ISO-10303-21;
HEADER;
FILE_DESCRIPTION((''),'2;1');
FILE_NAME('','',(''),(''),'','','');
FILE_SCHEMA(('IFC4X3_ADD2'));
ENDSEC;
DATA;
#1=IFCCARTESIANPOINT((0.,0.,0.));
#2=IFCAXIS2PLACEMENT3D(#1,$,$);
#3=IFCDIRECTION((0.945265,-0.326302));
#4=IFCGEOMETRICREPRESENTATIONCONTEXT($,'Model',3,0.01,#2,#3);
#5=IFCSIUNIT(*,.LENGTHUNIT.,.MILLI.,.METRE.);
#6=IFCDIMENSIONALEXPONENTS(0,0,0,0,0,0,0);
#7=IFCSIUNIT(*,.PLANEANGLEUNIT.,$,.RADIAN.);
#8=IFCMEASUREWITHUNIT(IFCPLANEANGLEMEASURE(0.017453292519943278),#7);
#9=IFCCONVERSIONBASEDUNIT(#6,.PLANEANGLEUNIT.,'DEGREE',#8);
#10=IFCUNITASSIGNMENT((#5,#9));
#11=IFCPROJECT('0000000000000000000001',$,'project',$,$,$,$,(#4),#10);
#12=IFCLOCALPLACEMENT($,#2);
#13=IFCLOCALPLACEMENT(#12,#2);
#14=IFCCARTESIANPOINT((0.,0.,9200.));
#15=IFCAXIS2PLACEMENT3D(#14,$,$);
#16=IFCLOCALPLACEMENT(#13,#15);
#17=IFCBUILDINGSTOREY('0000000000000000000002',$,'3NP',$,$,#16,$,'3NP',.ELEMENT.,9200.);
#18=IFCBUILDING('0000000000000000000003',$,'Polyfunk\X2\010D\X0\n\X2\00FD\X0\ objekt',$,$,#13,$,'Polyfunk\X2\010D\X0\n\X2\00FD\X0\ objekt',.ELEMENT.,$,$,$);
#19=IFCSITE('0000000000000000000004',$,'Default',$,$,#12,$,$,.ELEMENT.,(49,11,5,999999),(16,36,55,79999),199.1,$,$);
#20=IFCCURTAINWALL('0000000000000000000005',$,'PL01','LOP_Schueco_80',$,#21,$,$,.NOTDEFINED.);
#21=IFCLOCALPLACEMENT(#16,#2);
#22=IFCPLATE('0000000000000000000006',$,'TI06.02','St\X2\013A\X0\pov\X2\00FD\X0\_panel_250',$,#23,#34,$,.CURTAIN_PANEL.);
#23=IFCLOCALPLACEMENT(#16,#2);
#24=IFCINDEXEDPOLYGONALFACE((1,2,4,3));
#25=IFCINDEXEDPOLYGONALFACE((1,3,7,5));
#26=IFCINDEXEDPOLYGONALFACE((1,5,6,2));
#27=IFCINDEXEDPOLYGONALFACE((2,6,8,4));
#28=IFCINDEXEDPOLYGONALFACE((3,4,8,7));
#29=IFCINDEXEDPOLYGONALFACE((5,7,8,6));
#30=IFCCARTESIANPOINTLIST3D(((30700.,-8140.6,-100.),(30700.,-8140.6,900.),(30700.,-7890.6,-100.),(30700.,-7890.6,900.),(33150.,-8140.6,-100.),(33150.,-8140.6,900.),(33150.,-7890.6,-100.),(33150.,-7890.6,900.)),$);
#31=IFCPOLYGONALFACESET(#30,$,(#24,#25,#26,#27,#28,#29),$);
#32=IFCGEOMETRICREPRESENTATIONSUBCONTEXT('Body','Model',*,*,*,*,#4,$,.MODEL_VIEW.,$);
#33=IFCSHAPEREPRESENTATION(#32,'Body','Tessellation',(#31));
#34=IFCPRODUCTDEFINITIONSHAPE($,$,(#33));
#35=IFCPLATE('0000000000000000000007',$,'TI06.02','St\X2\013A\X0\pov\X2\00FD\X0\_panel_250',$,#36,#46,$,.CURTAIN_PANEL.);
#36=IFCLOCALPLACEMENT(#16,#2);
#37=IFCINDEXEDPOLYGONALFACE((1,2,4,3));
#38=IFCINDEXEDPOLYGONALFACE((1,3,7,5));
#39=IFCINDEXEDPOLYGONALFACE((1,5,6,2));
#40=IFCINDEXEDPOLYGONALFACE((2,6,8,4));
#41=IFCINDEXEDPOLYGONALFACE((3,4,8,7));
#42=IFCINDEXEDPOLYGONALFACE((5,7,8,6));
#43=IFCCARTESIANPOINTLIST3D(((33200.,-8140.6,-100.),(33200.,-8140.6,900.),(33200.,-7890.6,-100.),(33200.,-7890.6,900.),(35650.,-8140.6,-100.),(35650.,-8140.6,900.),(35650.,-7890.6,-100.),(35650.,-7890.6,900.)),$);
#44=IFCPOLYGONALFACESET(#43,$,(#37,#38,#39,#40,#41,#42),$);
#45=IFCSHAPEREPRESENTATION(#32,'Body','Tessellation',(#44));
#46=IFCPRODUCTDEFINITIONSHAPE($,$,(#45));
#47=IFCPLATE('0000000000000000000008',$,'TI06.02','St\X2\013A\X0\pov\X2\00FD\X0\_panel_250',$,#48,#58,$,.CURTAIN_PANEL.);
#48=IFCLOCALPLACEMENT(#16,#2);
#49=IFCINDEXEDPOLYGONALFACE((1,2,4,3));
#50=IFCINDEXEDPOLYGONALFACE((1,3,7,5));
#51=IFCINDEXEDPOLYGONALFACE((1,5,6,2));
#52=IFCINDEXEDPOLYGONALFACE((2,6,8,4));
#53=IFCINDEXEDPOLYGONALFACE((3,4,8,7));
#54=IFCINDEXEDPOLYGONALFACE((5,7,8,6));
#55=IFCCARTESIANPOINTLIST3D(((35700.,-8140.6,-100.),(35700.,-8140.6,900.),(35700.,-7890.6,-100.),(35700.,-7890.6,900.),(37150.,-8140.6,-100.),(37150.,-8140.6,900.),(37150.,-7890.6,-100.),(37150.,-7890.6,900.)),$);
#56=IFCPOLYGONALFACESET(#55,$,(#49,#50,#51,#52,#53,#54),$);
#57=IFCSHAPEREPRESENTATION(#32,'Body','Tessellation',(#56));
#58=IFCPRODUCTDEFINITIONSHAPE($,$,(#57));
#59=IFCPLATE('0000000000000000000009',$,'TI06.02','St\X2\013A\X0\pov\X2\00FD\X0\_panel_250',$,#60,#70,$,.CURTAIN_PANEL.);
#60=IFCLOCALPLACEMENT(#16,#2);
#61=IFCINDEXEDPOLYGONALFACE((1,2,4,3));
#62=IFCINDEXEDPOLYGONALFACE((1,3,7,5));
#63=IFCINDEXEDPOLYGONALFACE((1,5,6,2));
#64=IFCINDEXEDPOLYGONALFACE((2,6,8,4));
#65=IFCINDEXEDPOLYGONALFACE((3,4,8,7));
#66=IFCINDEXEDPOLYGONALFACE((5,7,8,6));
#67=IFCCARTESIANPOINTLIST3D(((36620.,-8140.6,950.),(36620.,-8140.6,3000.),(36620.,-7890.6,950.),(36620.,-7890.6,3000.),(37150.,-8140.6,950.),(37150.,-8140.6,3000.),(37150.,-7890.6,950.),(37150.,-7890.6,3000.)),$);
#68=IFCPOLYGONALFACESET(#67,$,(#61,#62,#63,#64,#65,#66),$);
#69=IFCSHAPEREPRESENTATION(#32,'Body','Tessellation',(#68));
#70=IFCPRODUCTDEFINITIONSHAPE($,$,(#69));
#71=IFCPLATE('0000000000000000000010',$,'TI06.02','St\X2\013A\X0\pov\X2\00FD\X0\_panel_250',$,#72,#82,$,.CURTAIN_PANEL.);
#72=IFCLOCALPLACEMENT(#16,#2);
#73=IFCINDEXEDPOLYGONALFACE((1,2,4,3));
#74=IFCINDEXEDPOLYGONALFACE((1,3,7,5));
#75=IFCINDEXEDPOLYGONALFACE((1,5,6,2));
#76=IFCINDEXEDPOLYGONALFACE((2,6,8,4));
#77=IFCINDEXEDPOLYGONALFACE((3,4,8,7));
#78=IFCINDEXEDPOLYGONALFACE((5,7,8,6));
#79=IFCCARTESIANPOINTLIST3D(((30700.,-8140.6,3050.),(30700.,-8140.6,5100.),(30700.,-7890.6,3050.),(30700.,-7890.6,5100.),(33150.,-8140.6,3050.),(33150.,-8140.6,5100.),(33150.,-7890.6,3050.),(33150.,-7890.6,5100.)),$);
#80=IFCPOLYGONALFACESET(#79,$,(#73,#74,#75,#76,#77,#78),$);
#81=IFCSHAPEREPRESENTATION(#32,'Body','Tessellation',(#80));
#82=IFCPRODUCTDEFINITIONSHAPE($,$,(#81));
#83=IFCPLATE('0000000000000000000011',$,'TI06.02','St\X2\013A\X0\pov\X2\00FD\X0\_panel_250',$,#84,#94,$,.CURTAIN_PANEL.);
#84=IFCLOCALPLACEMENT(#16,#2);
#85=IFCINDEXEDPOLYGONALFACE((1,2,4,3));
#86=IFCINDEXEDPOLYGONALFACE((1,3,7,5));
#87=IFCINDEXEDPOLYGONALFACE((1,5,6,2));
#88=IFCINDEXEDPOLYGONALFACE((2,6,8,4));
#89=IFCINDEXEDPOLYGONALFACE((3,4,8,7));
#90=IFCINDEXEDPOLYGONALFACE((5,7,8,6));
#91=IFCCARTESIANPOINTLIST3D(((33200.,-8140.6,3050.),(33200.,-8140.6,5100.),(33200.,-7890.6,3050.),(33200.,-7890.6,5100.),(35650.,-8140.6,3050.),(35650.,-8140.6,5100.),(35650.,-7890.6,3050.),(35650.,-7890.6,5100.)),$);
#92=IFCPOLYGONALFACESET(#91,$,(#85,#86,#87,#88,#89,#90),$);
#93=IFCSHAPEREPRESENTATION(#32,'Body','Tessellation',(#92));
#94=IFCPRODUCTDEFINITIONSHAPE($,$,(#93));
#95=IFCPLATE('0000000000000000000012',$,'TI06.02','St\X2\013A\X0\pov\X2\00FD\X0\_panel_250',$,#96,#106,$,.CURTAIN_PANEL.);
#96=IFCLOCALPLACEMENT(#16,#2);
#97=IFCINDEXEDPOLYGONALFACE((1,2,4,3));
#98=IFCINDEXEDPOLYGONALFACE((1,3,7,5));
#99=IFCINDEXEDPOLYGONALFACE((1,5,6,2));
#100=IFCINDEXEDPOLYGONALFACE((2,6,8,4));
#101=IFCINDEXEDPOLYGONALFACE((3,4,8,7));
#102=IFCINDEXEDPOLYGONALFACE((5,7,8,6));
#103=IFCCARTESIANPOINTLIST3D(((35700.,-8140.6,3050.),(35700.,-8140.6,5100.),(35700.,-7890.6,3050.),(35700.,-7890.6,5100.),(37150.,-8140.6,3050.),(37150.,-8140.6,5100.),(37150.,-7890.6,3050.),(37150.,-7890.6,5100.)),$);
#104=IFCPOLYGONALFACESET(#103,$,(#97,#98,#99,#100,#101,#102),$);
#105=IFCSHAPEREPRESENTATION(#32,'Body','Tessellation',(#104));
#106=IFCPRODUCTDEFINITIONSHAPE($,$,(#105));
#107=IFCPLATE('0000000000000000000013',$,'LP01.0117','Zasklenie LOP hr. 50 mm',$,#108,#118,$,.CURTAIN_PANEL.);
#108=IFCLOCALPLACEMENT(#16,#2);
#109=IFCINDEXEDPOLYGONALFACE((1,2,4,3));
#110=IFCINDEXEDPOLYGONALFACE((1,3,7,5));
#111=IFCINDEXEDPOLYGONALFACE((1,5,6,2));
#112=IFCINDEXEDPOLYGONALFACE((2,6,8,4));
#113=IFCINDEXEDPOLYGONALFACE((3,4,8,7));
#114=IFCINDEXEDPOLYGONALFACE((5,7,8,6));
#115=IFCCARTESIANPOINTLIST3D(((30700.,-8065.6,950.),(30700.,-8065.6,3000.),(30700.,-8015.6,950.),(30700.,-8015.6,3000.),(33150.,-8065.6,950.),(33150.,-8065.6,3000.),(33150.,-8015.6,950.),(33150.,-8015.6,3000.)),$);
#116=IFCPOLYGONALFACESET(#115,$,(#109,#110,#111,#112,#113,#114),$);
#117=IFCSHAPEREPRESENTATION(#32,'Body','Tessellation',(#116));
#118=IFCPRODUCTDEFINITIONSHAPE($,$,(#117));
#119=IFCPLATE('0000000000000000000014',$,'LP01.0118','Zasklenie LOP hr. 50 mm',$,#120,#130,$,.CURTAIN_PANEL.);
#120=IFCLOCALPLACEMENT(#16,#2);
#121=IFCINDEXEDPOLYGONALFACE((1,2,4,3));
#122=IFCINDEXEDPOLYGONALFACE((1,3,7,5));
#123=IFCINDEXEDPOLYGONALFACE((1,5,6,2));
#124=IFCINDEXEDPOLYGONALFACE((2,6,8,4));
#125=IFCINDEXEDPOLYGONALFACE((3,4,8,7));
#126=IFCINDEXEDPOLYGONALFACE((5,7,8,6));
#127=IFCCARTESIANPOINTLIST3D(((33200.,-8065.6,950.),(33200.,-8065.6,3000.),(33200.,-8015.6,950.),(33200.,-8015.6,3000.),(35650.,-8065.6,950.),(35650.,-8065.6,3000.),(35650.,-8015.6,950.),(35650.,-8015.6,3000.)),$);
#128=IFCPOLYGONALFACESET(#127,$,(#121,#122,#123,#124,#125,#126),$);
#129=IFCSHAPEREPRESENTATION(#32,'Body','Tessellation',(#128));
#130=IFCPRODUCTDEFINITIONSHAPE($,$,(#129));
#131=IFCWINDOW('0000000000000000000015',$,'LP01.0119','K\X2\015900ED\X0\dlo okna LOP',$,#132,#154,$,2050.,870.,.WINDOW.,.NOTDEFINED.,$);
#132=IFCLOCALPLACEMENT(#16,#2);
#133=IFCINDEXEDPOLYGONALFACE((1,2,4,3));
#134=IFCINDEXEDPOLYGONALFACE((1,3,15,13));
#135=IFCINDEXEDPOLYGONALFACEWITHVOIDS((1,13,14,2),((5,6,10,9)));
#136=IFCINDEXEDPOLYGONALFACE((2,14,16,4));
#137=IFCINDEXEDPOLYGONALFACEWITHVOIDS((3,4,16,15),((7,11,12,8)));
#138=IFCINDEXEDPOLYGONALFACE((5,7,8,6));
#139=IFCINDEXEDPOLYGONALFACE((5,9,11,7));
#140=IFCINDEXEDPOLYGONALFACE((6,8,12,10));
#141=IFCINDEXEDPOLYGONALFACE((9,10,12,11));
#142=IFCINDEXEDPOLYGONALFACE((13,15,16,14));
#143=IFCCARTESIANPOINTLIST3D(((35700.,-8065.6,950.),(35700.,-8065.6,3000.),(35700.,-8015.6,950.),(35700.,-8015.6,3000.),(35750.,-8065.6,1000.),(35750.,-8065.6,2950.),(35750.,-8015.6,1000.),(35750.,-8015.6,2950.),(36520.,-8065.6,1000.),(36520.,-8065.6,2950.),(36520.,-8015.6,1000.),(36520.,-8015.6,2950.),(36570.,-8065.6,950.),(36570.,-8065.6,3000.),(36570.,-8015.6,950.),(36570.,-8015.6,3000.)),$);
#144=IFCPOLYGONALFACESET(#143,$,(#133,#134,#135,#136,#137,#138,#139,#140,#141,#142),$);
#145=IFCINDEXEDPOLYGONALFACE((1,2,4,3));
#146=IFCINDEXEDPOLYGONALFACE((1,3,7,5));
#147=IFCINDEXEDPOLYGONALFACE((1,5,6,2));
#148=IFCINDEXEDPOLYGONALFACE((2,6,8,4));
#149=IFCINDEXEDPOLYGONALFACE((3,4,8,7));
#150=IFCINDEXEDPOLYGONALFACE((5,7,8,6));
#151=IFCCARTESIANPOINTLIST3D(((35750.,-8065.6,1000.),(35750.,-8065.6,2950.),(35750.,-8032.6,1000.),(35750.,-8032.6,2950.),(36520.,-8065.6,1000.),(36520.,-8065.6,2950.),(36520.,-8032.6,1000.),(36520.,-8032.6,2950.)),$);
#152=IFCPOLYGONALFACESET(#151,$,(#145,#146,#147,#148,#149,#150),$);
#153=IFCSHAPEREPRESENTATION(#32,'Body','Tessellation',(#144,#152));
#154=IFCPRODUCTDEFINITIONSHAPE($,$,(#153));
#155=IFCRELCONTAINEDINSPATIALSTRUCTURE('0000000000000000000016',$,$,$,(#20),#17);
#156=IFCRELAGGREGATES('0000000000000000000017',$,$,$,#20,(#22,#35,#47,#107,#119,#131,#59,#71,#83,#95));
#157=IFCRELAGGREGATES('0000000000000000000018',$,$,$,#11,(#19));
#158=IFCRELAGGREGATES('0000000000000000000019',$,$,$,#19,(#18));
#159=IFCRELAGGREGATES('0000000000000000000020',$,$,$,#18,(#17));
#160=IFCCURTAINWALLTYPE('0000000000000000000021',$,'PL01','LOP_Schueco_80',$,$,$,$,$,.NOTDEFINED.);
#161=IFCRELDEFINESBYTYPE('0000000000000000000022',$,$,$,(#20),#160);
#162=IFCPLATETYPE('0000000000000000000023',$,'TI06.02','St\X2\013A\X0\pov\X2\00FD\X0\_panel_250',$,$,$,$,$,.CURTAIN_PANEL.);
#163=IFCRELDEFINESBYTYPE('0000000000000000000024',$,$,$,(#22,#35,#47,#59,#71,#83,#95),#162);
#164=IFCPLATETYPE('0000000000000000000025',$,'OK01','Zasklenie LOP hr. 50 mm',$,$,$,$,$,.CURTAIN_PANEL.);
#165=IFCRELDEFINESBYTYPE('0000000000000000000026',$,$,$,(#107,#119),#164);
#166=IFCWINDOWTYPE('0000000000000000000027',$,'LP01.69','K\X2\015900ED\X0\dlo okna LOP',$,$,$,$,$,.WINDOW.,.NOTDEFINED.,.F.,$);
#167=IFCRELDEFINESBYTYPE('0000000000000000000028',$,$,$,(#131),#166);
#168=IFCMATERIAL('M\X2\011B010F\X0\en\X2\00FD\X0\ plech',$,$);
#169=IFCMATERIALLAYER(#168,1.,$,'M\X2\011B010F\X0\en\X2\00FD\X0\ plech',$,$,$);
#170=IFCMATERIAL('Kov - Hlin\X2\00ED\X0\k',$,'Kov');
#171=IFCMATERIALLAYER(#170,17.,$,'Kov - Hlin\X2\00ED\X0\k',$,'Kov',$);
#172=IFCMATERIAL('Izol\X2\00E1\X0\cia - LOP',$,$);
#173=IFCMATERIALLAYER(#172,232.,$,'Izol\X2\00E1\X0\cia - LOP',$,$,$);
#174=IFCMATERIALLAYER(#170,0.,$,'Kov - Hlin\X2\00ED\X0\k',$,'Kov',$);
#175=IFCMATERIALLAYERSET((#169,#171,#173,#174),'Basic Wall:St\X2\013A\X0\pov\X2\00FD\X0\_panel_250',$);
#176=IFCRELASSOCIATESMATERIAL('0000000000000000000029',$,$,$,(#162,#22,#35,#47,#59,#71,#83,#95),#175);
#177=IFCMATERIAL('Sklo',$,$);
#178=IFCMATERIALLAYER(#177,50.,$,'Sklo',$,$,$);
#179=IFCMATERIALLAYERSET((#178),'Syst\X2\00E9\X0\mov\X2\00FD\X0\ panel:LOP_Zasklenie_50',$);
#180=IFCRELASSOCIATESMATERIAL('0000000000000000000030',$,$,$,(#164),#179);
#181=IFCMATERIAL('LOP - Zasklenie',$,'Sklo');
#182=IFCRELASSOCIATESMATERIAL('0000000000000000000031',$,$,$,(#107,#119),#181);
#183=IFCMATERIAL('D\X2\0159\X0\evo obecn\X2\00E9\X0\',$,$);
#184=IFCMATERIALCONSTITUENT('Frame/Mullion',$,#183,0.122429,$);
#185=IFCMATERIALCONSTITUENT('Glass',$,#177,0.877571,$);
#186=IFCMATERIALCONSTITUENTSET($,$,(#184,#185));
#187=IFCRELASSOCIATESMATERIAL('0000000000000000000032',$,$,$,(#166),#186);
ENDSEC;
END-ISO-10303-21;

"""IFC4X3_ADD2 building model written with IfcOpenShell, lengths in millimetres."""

from ifc_helpers import new_model, entity, si_unit, converted_unit, direction, frame, frame_2d, origin, origin_2d_with_axis, place, context, subcontext, project, spatial, polyline, rectangle, outline, extrude, source, transform, mapped, material, layer, layer_set, layer_usage, constituent, constituent_set, type_object, type_shapes, element, aggregate, save


model = new_model("IFC4X3_ADD2")

# Units and contexts
model_context = context("Model", 3, precision=0.01, world=origin(), true_north=direction((0.945265, -0.326302)))
body_context = subcontext(model_context, "Body", "Model", "MODEL_VIEW")
ifc_project = project(units=[si_unit("LENGTHUNIT", "METRE", prefix="MILLI"), converted_unit("PLANEANGLEUNIT", "DEGREE", entity("IfcPlaneAngleMeasure", 0.017453292519943278), si_unit("PLANEANGLEUNIT", "RADIAN"), dimensions=[0, 0, 0, 0, 0, 0, 0])], contexts=[model_context])

# Site, building, storey
site_placement = place(None, origin())
site = spatial("IfcSite", under=ifc_project, at=site_placement, Name="Default", CompositionType="ELEMENT", RefLatitude=(49, 11, 5, 999999), RefLongitude=(16, 36, 55, 79999), RefElevation=199.1)
building_placement = place(site_placement, origin())
building = spatial("IfcBuilding", under=site, at=building_placement, Name="Polyfunkčný objekt", LongName="Polyfunkčný objekt", CompositionType="ELEMENT")
storey_placement = place(building_placement, frame((0.0, 0.0, 9200.0)))
storey = spatial("IfcBuildingStorey", under=building, at=storey_placement, Name="3NP", LongName="3NP", CompositionType="ELEMENT", Elevation=9200.0)

# Curtain wall, plates
curtain_wall_type = type_object("IfcCurtainWallType", Name="PL01", Description="LOP_Schueco_80", PredefinedType="NOTDEFINED")
curtain_wall_placement = place(storey_placement, frame((0.0, 0.0, -9200.0)))
curtain_wall = element("IfcCurtainWall", 1, at=curtain_wall_placement, inside=storey, type_object=curtain_wall_type, Name="PL01", Description="LOP_Schueco_80", PredefinedType="NOTDEFINED")
ifc_material_1 = material(Name="Měďený plech")
ifc_layer_1 = layer(ifc_material_1, 1.0, Name="Měďený plech")
ifc_material_2 = material(Name="Kov - Hliník", Category="Kov")
ifc_layer_2 = layer(ifc_material_2, 17.0, Name="Kov - Hliník", Category="Kov")
ifc_material_3 = material(Name="Izolácia - LOP")
ifc_layer_3 = layer(ifc_material_3, 232.0, Name="Izolácia - LOP")
ifc_layer_4 = layer(ifc_material_2, 0.0, Name="Kov - Hliník", Category="Kov")
ifc_layer_set_1 = layer_set([ifc_layer_1, ifc_layer_2, ifc_layer_3, ifc_layer_4], Name="Basic Wall:Stĺpový_panel_250")
ifc_layer_usage_1 = layer_usage(ifc_layer_set_1, "AXIS2", "POSITIVE", -125.0)
plate_type_1 = type_object("IfcPlateType", Name="TI06.02", Description="Stĺpový_panel_250", PredefinedType="CURTAIN_PANEL", material=ifc_layer_set_1)
plate_1_placement = place(storey_placement, frame((30700.0, -8015.6, -100.0)))
plate_1 = element("IfcPlate", 2, at=plate_1_placement, type_object=plate_type_1, material=ifc_layer_usage_1, Name="TI06.02", Description="Stĺpový_panel_250", PredefinedType="CURTAIN_PANEL", context=body_context, shape_type="SweptSolid", body=[
    extrude(rectangle(XDim=250.0, YDim=2450.0, at=frame_2d((0.0, 0.0), x_axis=(1.0, 0.0))), frame((1225.0, 0.0, 0.0), z_axis=(0.0, 0.0, 1.0), x_axis=(0.0, 1.0, 0.0)), (0.0, 0.0, 1.0), 1000.0),
])
ifc_layer_usage_2 = layer_usage(ifc_layer_set_1, "AXIS2", "POSITIVE", -125.0)
plate_2_placement = place(storey_placement, frame((33200.0, -8015.6, -100.0)))
plate_2 = element("IfcPlate", 3, at=plate_2_placement, type_object=plate_type_1, material=ifc_layer_usage_2, Name="TI06.02", Description="Stĺpový_panel_250", PredefinedType="CURTAIN_PANEL", context=body_context, shape_type="SweptSolid", body=[
    extrude(rectangle(XDim=250.0, YDim=2450.0, at=frame_2d((0.0, 0.0), x_axis=(1.0, 0.0))), frame((1225.0, 0.0, 0.0), z_axis=(0.0, 0.0, 1.0), x_axis=(0.0, 1.0, 0.0)), (0.0, 0.0, 1.0), 1000.0),
])
ifc_layer_usage_3 = layer_usage(ifc_layer_set_1, "AXIS2", "POSITIVE", -125.0)
plate_3_placement = place(storey_placement, frame((35700.0, -8015.6, -100.0)))
plate_3 = element("IfcPlate", 4, at=plate_3_placement, type_object=plate_type_1, material=ifc_layer_usage_3, Name="TI06.02", Description="Stĺpový_panel_250", PredefinedType="CURTAIN_PANEL", context=body_context, shape_type="SweptSolid", body=[
    extrude(rectangle(XDim=250.0, YDim=1450.0, at=frame_2d((0.0, 0.0), x_axis=(1.0, 0.0))), frame((725.0, 0.0, 0.0), z_axis=(0.0, 0.0, 1.0), x_axis=(0.0, 1.0, 0.0)), (0.0, 0.0, 1.0), 1000.0),
])
ifc_layer_usage_4 = layer_usage(ifc_layer_set_1, "AXIS2", "POSITIVE", -125.0)
plate_4_placement = place(storey_placement, frame((36620.0, -8015.6, 950.0)))
plate_4 = element("IfcPlate", 5, at=plate_4_placement, type_object=plate_type_1, material=ifc_layer_usage_4, Name="TI06.02", Description="Stĺpový_panel_250", PredefinedType="CURTAIN_PANEL", context=body_context, shape_type="SweptSolid", body=[
    extrude(rectangle(XDim=250.0, YDim=530.0, at=frame_2d((0.0, 0.0), x_axis=(1.0, 0.0))), frame((265.0, 0.0, 0.0), z_axis=(0.0, 0.0, 1.0), x_axis=(0.0, 1.0, 0.0)), (0.0, 0.0, 1.0), 2050.0),
])
ifc_layer_usage_5 = layer_usage(ifc_layer_set_1, "AXIS2", "POSITIVE", -125.0)
plate_5_placement = place(storey_placement, frame((30700.0, -8015.6, 3050.0)))
plate_5 = element("IfcPlate", 6, at=plate_5_placement, type_object=plate_type_1, material=ifc_layer_usage_5, Name="TI06.02", Description="Stĺpový_panel_250", PredefinedType="CURTAIN_PANEL", context=body_context, shape_type="SweptSolid", body=[
    extrude(rectangle(XDim=250.0, YDim=2450.0, at=frame_2d((0.0, 0.0), x_axis=(1.0, 0.0))), frame((1225.0, 0.0, 0.0), z_axis=(0.0, 0.0, 1.0), x_axis=(0.0, 1.0, 0.0)), (0.0, 0.0, 1.0), 2050.0),
])
ifc_layer_usage_6 = layer_usage(ifc_layer_set_1, "AXIS2", "POSITIVE", -125.0)
plate_6_placement = place(storey_placement, frame((33200.0, -8015.6, 3050.0)))
plate_6 = element("IfcPlate", 7, at=plate_6_placement, type_object=plate_type_1, material=ifc_layer_usage_6, Name="TI06.02", Description="Stĺpový_panel_250", PredefinedType="CURTAIN_PANEL", context=body_context, shape_type="SweptSolid", body=[
    extrude(rectangle(XDim=250.0, YDim=2450.0, at=frame_2d((0.0, 0.0), x_axis=(1.0, 0.0))), frame((1225.0, 0.0, 0.0), z_axis=(0.0, 0.0, 1.0), x_axis=(0.0, 1.0, 0.0)), (0.0, 0.0, 1.0), 2050.0),
])
ifc_layer_usage_7 = layer_usage(ifc_layer_set_1, "AXIS2", "POSITIVE", -125.0)
plate_7_placement = place(storey_placement, frame((35700.0, -8015.6, 3050.0)))
plate_7 = element("IfcPlate", 8, at=plate_7_placement, type_object=plate_type_1, material=ifc_layer_usage_7, Name="TI06.02", Description="Stĺpový_panel_250", PredefinedType="CURTAIN_PANEL", context=body_context, shape_type="SweptSolid", body=[
    extrude(rectangle(XDim=250.0, YDim=1450.0, at=frame_2d((0.0, 0.0), x_axis=(1.0, 0.0))), frame((725.0, 0.0, 0.0), z_axis=(0.0, 0.0, 1.0), x_axis=(0.0, 1.0, 0.0)), (0.0, 0.0, 1.0), 2050.0),
])
ifc_material_4 = material(Name="LOP - Zasklenie", Category="Sklo")
ifc_material_5 = material(Name="Sklo")
ifc_layer_5 = layer(ifc_material_5, 50.0, Name="Sklo")
ifc_layer_set_2 = layer_set([ifc_layer_5], Name="Systémový panel:LOP_Zasklenie_50")
plate_type_2 = type_object("IfcPlateType", Name="OK01", Description="Zasklenie LOP hr. 50 mm", PredefinedType="CURTAIN_PANEL", material=ifc_layer_set_2)
shared_shape_1 = source(origin(), body_context, "Body", "SweptSolid", [
    extrude(rectangle(XDim=50.0, YDim=2450.0, at=origin_2d_with_axis()), frame((0.0, -25.0, 0.0), z_axis=(0.0, 0.0, 1.0), x_axis=(0.0, 1.0, 0.0)), (0.0, 0.0, 1.0), 2050.0),
])
type_shapes(plate_type_2, [shared_shape_1])
plate_8_placement = place(curtain_wall_placement, frame((31925.0, -8015.6, 10150.0)))
plate_8 = element("IfcPlate", 9, at=plate_8_placement, type_object=plate_type_2, material=ifc_material_4, Name="LP01.0117", Description="Zasklenie LOP hr. 50 mm", PredefinedType="CURTAIN_PANEL", context=body_context, shape_type="MappedRepresentation", body=[
    mapped(shared_shape_1, transform((0.0, 0.0, 0.0), scale=1.0)),
])
plate_9_placement = place(curtain_wall_placement, frame((34425.0, -8015.6, 10150.0)))
plate_9 = element("IfcPlate", 10, at=plate_9_placement, type_object=plate_type_2, material=ifc_material_4, Name="LP01.0118", Description="Zasklenie LOP hr. 50 mm", PredefinedType="CURTAIN_PANEL", context=body_context, shape_type="MappedRepresentation", body=[
    mapped(shared_shape_1, transform((0.0, 0.0, 0.0), scale=1.0)),
])

# Window
ifc_material_6 = material(Name="Dřevo obecné")
ifc_constituent_1 = constituent(ifc_material_6, Name="Frame/Mullion", fraction=0.122429)
ifc_constituent_2 = constituent(ifc_material_5, Name="Glass", fraction=0.877571)
ifc_constituent_set = constituent_set(constituents=[ifc_constituent_1, ifc_constituent_2])
window_type = type_object("IfcWindowType", Name="LP01.69", Description="Křídlo okna LOP", ParameterTakesPrecedence=False, PartitioningType="NOTDEFINED", PredefinedType="WINDOW", material=ifc_constituent_set)
shared_shape_2 = source(origin(), body_context, "Body", "SweptSolid", [
    extrude(outline(polyline([(-1025.0, -435.0), (1025.0, -435.0), (1025.0, 435.0), (-1025.0, 435.0), (-1025.0, -435.0)]), holes=[polyline([(-975.0, -385.0), (-975.0, 385.0), (975.0, 385.0), (975.0, -385.0), (-975.0, -385.0)])]), frame((0.0, 50.0, 1025.0), z_axis=(0.0, -1.0, 0.0), x_axis=(0.0, 0.0, -1.0)), (0.0, 0.0, 1.0), 50.0),
    extrude(rectangle(XDim=770.0, YDim=33.0, at=frame_2d((0.0, 0.0), x_axis=(1.0, 0.0))), frame((0.0, 33.5, 50.0), z_axis=(0.0, 0.0, 1.0), x_axis=(-1.0, 0.0, 0.0)), (0.0, 0.0, 1.0), 1950.0),
])
type_shapes(window_type, [shared_shape_2])
window_placement = place(curtain_wall_placement, frame((36135.0, -8015.6, 10150.0), z_axis=(0.0, 0.0, 1.0), x_axis=(-1.0, 0.0, 0.0)))
window = element("IfcWindow", 11, at=window_placement, type_object=window_type, Name="LP01.0119", Description="Křídlo okna LOP", OverallHeight=2050.0, OverallWidth=870.0, PartitioningType="NOTDEFINED", PredefinedType="WINDOW", context=body_context, shape_type="MappedRepresentation", body=[
    mapped(shared_shape_2, transform((0.0, 0.0, 0.0), scale=1.0)),
])
aggregate(curtain_wall, [plate_1, plate_2, plate_3, plate_8, plate_9, window, plate_4, plate_5, plate_6, plate_7])

save(model, "model.ifc")
